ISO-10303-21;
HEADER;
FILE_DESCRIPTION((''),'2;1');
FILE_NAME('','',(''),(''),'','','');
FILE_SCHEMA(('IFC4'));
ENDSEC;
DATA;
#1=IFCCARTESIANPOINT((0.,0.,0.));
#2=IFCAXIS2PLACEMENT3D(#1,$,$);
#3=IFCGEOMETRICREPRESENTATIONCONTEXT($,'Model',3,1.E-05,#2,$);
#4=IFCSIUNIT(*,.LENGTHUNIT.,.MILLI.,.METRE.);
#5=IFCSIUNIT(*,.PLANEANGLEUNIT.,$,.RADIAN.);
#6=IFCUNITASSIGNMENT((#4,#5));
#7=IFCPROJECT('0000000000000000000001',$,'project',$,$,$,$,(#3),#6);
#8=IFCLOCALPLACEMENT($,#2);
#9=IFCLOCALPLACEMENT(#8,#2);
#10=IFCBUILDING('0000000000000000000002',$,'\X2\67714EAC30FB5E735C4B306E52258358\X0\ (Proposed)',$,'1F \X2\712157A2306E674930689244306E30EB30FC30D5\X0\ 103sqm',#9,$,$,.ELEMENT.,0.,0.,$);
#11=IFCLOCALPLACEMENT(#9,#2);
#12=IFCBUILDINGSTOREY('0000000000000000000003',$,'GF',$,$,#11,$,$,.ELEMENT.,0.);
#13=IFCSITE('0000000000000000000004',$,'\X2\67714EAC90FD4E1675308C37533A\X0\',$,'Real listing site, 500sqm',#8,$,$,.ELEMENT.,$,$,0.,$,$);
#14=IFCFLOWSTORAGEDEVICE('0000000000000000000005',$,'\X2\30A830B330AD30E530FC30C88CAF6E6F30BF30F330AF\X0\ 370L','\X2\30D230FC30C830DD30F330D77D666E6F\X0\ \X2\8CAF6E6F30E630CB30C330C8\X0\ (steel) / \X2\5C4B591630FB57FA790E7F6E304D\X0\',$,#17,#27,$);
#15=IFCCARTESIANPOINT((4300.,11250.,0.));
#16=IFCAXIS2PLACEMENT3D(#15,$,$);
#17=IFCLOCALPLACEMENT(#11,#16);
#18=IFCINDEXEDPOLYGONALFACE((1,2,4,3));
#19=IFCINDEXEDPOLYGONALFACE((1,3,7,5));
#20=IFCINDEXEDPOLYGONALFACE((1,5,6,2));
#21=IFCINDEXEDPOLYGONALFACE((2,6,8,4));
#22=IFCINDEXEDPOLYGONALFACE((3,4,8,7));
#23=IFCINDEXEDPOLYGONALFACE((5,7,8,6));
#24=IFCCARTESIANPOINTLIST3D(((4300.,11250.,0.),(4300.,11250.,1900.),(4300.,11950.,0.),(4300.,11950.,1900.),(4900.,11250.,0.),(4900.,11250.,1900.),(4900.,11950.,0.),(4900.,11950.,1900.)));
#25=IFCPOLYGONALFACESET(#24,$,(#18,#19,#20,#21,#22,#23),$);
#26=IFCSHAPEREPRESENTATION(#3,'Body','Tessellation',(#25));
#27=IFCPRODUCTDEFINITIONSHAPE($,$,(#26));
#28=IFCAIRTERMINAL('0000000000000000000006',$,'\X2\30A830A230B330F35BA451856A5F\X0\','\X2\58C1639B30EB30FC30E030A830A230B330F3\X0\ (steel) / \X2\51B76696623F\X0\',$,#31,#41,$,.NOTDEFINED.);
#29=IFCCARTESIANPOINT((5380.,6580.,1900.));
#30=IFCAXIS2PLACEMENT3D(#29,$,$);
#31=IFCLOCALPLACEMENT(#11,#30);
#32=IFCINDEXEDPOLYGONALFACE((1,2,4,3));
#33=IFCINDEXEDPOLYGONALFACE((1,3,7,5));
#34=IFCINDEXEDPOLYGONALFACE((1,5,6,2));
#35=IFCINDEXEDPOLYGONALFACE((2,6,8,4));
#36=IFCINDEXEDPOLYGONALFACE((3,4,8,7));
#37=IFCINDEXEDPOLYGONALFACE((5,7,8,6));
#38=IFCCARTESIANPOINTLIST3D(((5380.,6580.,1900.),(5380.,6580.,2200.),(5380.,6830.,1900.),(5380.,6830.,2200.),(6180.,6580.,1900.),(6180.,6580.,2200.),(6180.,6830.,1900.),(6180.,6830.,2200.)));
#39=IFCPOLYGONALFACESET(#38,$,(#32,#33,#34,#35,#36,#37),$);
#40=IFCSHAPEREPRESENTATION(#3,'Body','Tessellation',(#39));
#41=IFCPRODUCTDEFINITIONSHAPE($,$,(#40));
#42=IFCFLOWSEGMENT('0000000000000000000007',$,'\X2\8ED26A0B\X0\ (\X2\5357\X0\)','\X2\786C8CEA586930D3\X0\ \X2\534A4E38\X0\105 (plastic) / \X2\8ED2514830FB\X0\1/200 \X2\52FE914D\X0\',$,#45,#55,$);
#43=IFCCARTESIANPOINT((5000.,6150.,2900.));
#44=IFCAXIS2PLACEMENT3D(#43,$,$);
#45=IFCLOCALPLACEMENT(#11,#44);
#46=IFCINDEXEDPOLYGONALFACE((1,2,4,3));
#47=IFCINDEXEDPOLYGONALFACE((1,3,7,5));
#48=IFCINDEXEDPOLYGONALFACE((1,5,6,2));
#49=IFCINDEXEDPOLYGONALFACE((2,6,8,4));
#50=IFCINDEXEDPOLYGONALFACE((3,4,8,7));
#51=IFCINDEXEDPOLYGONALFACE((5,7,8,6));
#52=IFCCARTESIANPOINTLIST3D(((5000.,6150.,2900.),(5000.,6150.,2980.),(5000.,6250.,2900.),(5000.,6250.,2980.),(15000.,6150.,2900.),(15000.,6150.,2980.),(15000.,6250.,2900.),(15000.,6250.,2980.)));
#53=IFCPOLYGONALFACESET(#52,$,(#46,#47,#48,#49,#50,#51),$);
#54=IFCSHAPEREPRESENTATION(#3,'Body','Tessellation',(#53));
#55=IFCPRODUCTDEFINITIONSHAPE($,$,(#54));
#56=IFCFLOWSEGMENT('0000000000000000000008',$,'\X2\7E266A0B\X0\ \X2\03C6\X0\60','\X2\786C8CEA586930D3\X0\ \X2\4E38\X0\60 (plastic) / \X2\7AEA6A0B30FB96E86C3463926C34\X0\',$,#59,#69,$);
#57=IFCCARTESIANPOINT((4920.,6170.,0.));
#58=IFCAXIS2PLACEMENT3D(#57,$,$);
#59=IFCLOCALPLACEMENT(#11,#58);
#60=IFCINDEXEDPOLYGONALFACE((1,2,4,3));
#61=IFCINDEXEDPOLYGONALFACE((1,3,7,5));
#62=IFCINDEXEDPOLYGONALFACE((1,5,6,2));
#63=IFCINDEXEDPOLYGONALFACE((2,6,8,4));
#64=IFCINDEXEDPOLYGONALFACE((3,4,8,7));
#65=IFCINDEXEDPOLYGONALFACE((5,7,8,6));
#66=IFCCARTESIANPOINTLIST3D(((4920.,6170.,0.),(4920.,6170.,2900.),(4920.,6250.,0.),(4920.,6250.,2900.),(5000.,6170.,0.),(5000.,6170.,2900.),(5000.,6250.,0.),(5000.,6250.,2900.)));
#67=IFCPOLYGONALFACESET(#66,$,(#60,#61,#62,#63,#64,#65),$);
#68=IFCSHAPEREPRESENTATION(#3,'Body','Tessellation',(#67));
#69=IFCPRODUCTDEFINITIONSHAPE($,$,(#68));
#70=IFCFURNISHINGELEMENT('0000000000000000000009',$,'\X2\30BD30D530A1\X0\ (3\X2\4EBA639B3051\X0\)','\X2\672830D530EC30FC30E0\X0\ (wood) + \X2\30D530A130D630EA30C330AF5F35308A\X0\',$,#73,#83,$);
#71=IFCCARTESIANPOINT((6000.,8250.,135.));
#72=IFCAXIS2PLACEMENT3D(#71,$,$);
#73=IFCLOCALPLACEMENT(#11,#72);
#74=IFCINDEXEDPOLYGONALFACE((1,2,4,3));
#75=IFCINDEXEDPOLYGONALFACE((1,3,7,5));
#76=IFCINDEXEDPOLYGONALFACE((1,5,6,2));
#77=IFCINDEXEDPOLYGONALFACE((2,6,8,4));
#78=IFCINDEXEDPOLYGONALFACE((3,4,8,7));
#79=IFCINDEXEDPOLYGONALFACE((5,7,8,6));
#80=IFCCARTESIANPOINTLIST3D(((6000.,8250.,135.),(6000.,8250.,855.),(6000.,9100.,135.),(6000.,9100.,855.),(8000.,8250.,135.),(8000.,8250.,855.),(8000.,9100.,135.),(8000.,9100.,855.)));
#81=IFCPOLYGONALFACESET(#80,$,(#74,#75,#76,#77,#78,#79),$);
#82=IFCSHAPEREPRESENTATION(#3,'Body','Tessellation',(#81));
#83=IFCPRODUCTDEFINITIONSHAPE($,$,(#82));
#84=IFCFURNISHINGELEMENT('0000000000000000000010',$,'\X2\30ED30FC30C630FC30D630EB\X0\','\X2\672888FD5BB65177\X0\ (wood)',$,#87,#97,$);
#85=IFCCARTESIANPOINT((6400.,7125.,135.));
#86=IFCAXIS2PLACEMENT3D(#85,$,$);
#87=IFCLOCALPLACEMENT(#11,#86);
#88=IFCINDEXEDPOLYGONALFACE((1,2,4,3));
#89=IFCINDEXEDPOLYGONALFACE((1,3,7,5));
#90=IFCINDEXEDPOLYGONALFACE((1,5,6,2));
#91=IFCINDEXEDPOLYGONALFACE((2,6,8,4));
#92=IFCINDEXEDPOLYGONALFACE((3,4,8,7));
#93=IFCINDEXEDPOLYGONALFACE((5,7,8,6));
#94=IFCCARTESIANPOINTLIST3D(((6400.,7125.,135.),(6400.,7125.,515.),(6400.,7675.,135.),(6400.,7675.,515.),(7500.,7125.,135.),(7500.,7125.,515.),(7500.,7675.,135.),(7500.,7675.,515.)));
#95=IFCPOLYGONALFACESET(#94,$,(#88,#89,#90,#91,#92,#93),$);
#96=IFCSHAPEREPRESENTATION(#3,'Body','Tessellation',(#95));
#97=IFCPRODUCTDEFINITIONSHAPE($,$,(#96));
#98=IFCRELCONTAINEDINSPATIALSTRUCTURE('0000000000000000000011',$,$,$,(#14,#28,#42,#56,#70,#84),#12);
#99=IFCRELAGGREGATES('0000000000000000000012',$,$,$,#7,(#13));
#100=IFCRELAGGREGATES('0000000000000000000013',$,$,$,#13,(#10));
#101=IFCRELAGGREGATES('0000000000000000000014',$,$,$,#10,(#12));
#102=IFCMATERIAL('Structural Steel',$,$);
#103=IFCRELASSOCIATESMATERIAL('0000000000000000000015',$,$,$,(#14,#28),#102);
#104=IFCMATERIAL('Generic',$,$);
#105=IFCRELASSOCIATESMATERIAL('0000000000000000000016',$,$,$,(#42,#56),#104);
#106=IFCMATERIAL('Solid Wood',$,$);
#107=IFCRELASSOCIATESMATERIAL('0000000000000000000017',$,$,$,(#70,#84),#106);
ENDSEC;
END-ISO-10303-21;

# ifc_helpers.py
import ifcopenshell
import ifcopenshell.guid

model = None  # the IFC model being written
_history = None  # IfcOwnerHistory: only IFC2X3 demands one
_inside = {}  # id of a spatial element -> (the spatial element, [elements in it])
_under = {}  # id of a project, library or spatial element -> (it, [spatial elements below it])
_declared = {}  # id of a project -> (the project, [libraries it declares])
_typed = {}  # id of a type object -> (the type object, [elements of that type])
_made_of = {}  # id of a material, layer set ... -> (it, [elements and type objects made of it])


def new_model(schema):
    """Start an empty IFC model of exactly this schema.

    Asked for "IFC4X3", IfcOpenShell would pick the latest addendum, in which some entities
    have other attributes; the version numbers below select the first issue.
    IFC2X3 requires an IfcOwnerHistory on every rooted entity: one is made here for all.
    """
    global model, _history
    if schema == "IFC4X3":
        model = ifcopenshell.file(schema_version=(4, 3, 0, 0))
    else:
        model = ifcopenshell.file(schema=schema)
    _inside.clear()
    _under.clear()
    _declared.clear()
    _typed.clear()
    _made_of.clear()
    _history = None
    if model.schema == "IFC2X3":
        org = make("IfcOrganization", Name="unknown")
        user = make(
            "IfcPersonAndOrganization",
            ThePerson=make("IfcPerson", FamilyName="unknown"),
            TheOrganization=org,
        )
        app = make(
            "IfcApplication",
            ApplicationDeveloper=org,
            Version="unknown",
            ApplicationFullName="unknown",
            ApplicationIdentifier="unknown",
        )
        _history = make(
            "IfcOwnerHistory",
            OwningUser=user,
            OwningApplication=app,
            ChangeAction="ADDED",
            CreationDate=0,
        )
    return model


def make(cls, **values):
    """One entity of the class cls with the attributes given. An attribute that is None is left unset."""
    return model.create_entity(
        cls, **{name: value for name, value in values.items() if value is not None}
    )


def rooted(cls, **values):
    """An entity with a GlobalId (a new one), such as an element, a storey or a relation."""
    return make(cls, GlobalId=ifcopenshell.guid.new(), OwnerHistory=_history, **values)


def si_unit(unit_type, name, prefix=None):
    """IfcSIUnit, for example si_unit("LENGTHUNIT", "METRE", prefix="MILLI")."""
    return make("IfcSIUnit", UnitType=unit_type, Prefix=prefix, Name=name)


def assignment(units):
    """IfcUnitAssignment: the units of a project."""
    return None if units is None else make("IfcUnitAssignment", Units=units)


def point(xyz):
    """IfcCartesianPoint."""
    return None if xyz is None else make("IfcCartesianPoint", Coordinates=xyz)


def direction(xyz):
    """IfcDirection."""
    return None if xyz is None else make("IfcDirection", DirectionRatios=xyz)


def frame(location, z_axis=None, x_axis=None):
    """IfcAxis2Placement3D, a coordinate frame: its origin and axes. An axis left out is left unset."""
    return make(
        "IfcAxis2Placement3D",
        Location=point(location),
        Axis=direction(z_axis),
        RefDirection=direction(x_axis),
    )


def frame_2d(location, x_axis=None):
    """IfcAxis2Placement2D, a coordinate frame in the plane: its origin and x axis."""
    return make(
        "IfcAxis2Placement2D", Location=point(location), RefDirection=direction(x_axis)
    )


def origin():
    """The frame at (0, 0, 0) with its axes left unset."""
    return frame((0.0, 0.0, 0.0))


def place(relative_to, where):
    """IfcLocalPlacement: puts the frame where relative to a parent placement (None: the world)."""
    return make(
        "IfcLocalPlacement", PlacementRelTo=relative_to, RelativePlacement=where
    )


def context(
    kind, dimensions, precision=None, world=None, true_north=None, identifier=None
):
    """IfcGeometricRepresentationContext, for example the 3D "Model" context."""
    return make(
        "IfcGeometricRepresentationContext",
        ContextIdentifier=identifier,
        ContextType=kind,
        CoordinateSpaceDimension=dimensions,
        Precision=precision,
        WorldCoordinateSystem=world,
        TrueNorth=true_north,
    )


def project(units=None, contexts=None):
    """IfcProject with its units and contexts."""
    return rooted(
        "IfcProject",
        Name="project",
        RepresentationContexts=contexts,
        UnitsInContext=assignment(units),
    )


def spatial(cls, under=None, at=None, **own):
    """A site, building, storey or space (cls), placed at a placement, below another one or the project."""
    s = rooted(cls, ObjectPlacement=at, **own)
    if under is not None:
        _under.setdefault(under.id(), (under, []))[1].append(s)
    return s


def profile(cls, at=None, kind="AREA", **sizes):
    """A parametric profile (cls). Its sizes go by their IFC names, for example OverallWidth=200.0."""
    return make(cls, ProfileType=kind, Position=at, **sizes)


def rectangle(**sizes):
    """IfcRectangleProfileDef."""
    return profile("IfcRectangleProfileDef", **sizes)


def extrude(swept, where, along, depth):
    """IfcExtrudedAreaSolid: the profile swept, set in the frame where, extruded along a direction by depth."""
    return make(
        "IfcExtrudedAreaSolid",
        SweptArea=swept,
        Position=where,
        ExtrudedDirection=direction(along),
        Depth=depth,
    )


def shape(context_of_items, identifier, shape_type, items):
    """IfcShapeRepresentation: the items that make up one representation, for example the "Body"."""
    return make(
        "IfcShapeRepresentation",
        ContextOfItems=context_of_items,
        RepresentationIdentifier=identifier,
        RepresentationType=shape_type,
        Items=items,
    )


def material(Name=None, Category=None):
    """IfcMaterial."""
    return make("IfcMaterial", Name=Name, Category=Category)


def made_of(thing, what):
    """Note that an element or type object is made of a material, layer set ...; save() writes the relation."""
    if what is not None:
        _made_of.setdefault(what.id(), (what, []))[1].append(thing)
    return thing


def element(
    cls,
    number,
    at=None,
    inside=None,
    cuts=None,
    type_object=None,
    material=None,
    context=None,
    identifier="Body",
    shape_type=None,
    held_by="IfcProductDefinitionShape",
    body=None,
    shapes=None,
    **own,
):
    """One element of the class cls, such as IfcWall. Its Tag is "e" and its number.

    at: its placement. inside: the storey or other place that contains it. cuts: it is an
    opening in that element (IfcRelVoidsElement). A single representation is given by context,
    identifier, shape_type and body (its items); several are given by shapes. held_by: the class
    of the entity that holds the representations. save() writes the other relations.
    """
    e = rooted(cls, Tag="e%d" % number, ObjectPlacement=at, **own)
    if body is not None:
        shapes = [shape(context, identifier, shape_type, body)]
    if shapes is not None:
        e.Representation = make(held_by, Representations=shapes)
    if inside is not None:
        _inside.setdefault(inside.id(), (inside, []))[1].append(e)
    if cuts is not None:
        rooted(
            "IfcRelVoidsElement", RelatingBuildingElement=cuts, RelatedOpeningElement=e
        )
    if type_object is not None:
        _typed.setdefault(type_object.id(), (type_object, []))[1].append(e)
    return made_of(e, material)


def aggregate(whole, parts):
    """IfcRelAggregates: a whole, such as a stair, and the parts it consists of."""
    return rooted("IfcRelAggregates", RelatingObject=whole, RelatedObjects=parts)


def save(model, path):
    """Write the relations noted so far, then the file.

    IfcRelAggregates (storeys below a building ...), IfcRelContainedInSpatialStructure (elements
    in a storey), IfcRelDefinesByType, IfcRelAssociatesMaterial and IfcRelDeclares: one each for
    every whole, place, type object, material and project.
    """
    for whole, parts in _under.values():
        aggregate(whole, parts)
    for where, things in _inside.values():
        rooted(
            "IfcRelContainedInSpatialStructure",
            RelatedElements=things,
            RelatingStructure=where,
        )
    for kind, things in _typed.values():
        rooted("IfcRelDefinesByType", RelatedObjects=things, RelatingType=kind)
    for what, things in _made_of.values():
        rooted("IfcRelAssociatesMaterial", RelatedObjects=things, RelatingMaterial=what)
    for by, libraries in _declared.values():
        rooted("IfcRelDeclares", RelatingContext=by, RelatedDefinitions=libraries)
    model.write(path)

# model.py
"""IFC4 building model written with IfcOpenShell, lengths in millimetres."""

from ifc_helpers import new_model, si_unit, frame, frame_2d, origin, place, context, project, spatial, rectangle, extrude, material, element, save


model = new_model("IFC4")

# Units and contexts
model_context = context("Model", 3, precision=1e-05, world=origin())
ifc_project = project(units=[si_unit("LENGTHUNIT", "METRE", prefix="MILLI"), si_unit("PLANEANGLEUNIT", "RADIAN")], contexts=[model_context])

# Site, building, storey
site_placement = place(None, origin())
site = spatial("IfcSite", under=ifc_project, at=site_placement, Name="東京都世田谷区", ObjectType="Real listing site, 500sqm", CompositionType="ELEMENT", RefElevation=0.0)
building_placement = place(site_placement, origin())
building = spatial("IfcBuilding", under=site, at=building_placement, Name="東京・平屋の別荘 (Proposed)", ObjectType="1F 無垢の杉と鉄のルーフ 103sqm", CompositionType="ELEMENT", ElevationOfRefHeight=0.0, ElevationOfTerrain=0.0)
storey_placement = place(building_placement, origin())
storey = spatial("IfcBuildingStorey", under=building, at=storey_placement, Name="GF", CompositionType="ELEMENT", Elevation=0.0)

# Shared definitions
ifc_material_1 = material(Name="Solid Wood")

# Shared definitions
ifc_material_2 = material(Name="Structural Steel")

# Shared definitions
ifc_material_3 = material(Name="Generic")

# Flow storage device
flow_storage_device_placement = place(storey_placement, frame((4300.0, 11250.0, 0.0)))
element("IfcFlowStorageDevice", 1, at=flow_storage_device_placement, inside=storey, material=ifc_material_2, Name="エコキュート貯湯タンク 370L", Description="ヒートポンプ給湯 貯湯ユニット (steel) / 屋外・基礎置き", context=model_context, shape_type="SweptSolid", body=[
    extrude(rectangle(XDim=600.0, YDim=700.0, at=frame_2d((300.0, 350.0))), frame((4300.0, 11250.0, 0.0)), (0.0, 0.0, 1.0), 1900.0),
])

# Air terminal
air_terminal_placement = place(storey_placement, frame((5380.0, 6580.0, 1900.0)))
element("IfcAirTerminal", 2, at=air_terminal_placement, inside=storey, material=ifc_material_2, Name="エアコン室内機", Description="壁掛ルームエアコン (steel) / 冷暖房", PredefinedType="NOTDEFINED", context=model_context, shape_type="SweptSolid", body=[
    extrude(rectangle(XDim=800.0, YDim=250.0, at=frame_2d((400.0, 125.0))), frame((5380.0, 6580.0, 1900.0)), (0.0, 0.0, 1.0), 300.0),
])

# Flow segments
flow_segment_1_placement = place(storey_placement, frame((5000.0, 6150.0, 2900.0)))
element("IfcFlowSegment", 3, at=flow_segment_1_placement, inside=storey, material=ifc_material_3, Name="軒樋 (南)", Description="硬質塩ビ 半丸105 (plastic) / 軒先・1/200 勾配", context=model_context, shape_type="SweptSolid", body=[
    extrude(rectangle(XDim=10000.0, YDim=100.0, at=frame_2d((5000.0, 50.0))), frame((5000.0, 6150.0, 2900.0)), (0.0, 0.0, 1.0), 80.0),
])
flow_segment_2_placement = place(storey_placement, frame((4920.0, 6170.0, 0.0)))
element("IfcFlowSegment", 4, at=flow_segment_2_placement, inside=storey, material=ifc_material_3, Name="縦樋 φ60", Description="硬質塩ビ 丸60 (plastic) / 竪樋・雨水排水", context=model_context, shape_type="SweptSolid", body=[
    extrude(rectangle(XDim=80.0, YDim=80.0, at=frame_2d((40.0, 40.0))), frame((4920.0, 6170.0, 0.0)), (0.0, 0.0, 1.0), 2900.0),
])

# Furnishing elements
furnishing_1_placement = place(storey_placement, frame((6000.0, 8250.0, 135.0)))
element("IfcFurnishingElement", 5, at=furnishing_1_placement, inside=storey, material=ifc_material_1, Name="ソファ (3人掛け)", Description="木フレーム (wood) + ファブリック張り", context=model_context, shape_type="SweptSolid", body=[
    extrude(rectangle(XDim=2000.0, YDim=850.0, at=frame_2d((1000.0, 425.0))), frame((6000.0, 8250.0, 135.0)), (0.0, 0.0, 1.0), 720.0),
])
furnishing_2_placement = place(storey_placement, frame((6400.0, 7125.0, 135.0)))
element("IfcFurnishingElement", 6, at=furnishing_2_placement, inside=storey, material=ifc_material_1, Name="ローテーブル", Description="木製家具 (wood)", context=model_context, shape_type="SweptSolid", body=[
    extrude(rectangle(XDim=1100.0, YDim=550.0, at=frame_2d((550.0, 275.0))), frame((6400.0, 7125.0, 135.0)), (0.0, 0.0, 1.0), 380.0),
])

save(model, "model.ifc")
